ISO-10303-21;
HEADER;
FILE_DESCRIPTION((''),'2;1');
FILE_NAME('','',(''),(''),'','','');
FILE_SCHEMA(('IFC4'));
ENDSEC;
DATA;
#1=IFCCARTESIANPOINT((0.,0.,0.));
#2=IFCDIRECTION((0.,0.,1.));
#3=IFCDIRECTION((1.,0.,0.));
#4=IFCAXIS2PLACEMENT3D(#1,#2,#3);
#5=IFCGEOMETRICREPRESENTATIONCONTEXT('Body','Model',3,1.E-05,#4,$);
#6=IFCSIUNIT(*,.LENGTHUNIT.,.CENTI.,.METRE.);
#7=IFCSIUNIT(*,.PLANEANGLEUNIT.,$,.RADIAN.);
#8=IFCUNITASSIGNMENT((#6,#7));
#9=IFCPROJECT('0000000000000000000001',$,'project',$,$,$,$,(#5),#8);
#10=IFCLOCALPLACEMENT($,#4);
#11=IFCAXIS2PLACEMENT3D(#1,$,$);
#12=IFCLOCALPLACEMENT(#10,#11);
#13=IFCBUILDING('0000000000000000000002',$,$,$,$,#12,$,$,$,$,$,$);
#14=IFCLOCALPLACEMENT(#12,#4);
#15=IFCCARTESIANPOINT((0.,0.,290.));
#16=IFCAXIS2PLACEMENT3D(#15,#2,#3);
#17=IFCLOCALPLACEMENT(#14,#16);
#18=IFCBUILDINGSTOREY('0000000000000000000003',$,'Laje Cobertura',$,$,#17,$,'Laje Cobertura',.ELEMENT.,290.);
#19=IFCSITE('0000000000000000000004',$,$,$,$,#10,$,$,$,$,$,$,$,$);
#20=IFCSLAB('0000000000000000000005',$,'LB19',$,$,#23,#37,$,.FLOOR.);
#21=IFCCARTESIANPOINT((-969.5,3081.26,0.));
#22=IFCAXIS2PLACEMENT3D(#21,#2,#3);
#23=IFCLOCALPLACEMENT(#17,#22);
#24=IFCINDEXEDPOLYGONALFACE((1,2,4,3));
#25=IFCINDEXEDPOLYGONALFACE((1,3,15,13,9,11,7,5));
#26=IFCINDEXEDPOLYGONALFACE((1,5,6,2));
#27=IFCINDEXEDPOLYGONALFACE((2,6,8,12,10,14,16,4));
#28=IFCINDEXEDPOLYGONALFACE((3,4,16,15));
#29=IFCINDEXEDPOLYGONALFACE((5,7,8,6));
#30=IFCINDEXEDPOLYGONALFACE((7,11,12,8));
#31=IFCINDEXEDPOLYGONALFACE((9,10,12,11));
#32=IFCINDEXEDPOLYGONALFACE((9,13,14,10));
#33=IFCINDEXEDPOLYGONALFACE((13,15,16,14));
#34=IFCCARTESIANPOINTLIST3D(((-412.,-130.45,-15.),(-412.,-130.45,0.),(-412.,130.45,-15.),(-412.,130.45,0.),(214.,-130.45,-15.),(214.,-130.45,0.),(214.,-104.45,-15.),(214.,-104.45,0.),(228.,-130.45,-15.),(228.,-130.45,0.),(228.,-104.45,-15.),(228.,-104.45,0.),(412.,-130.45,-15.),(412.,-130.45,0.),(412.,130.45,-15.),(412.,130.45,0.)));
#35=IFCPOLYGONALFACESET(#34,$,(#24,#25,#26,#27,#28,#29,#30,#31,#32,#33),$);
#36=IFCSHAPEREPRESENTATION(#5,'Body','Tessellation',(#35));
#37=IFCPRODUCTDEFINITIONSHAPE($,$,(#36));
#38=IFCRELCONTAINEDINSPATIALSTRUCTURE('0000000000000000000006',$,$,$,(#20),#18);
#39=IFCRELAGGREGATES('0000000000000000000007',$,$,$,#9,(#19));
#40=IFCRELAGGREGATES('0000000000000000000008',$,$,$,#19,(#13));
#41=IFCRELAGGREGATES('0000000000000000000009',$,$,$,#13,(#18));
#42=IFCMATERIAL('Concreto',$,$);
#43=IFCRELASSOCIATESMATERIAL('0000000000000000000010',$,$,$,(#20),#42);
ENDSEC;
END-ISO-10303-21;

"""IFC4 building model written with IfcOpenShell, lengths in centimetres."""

from ifc_helpers import new_model, si_unit, frame, origin, origin_with_axes, place, context, project, spatial, polyline, outline, extrude, material, element, save


model = new_model("IFC4")

# Units and contexts
model_context = context("Model", 3, precision=1e-05, world=origin_with_axes(), identifier="Body")
ifc_project = project(units=[si_unit("LENGTHUNIT", "METRE", prefix="CENTI"), si_unit("PLANEANGLEUNIT", "RADIAN")], contexts=[model_context])

# Site, building, storey
site_placement = place(None, origin_with_axes())
site = spatial("IfcSite", under=ifc_project, at=site_placement)
building_placement = place(site_placement, origin())
building = spatial("IfcBuilding", under=site, at=building_placement)
placement = place(building_placement, origin_with_axes())
storey_placement = place(placement, frame((0.0, 0.0, 290.0), z_axis=(0.0, 0.0, 1.0), x_axis=(1.0, 0.0, 0.0)))
storey = spatial("IfcBuildingStorey", under=building, at=storey_placement, Name="Laje Cobertura", LongName="Laje Cobertura", CompositionType="ELEMENT", Elevation=290.0)

# Shared definitions
ifc_material = material(Name="Concreto")

# Slab
slab_1_placement = place(storey_placement, frame((-969.5, 3081.26, 0.0), z_axis=(0.0, 0.0, 1.0), x_axis=(1.0, 0.0, 0.0)))
element("IfcSlab", 1, at=slab_1_placement, inside=storey, material=ifc_material, Name="LB19", PredefinedType="FLOOR", context=model_context, shape_type="SolidModel", body=[
    extrude(outline(polyline([(214.0, -130.45), (214.0, -104.45), (228.0, -104.45), (228.0, -130.45), (412.0, -130.45), (412.0, 130.45), (-412.0, 130.45), (-412.0, -130.45), (214.0, -130.45), (214.0, -130.45)])), frame((0.0, 0.0, -15.0), z_axis=(0.0, 0.0, 1.0), x_axis=(1.0, 0.0, 0.0)), (0.0, 0.0, 1.0), 15.0),
])

save(model, "model.ifc")
